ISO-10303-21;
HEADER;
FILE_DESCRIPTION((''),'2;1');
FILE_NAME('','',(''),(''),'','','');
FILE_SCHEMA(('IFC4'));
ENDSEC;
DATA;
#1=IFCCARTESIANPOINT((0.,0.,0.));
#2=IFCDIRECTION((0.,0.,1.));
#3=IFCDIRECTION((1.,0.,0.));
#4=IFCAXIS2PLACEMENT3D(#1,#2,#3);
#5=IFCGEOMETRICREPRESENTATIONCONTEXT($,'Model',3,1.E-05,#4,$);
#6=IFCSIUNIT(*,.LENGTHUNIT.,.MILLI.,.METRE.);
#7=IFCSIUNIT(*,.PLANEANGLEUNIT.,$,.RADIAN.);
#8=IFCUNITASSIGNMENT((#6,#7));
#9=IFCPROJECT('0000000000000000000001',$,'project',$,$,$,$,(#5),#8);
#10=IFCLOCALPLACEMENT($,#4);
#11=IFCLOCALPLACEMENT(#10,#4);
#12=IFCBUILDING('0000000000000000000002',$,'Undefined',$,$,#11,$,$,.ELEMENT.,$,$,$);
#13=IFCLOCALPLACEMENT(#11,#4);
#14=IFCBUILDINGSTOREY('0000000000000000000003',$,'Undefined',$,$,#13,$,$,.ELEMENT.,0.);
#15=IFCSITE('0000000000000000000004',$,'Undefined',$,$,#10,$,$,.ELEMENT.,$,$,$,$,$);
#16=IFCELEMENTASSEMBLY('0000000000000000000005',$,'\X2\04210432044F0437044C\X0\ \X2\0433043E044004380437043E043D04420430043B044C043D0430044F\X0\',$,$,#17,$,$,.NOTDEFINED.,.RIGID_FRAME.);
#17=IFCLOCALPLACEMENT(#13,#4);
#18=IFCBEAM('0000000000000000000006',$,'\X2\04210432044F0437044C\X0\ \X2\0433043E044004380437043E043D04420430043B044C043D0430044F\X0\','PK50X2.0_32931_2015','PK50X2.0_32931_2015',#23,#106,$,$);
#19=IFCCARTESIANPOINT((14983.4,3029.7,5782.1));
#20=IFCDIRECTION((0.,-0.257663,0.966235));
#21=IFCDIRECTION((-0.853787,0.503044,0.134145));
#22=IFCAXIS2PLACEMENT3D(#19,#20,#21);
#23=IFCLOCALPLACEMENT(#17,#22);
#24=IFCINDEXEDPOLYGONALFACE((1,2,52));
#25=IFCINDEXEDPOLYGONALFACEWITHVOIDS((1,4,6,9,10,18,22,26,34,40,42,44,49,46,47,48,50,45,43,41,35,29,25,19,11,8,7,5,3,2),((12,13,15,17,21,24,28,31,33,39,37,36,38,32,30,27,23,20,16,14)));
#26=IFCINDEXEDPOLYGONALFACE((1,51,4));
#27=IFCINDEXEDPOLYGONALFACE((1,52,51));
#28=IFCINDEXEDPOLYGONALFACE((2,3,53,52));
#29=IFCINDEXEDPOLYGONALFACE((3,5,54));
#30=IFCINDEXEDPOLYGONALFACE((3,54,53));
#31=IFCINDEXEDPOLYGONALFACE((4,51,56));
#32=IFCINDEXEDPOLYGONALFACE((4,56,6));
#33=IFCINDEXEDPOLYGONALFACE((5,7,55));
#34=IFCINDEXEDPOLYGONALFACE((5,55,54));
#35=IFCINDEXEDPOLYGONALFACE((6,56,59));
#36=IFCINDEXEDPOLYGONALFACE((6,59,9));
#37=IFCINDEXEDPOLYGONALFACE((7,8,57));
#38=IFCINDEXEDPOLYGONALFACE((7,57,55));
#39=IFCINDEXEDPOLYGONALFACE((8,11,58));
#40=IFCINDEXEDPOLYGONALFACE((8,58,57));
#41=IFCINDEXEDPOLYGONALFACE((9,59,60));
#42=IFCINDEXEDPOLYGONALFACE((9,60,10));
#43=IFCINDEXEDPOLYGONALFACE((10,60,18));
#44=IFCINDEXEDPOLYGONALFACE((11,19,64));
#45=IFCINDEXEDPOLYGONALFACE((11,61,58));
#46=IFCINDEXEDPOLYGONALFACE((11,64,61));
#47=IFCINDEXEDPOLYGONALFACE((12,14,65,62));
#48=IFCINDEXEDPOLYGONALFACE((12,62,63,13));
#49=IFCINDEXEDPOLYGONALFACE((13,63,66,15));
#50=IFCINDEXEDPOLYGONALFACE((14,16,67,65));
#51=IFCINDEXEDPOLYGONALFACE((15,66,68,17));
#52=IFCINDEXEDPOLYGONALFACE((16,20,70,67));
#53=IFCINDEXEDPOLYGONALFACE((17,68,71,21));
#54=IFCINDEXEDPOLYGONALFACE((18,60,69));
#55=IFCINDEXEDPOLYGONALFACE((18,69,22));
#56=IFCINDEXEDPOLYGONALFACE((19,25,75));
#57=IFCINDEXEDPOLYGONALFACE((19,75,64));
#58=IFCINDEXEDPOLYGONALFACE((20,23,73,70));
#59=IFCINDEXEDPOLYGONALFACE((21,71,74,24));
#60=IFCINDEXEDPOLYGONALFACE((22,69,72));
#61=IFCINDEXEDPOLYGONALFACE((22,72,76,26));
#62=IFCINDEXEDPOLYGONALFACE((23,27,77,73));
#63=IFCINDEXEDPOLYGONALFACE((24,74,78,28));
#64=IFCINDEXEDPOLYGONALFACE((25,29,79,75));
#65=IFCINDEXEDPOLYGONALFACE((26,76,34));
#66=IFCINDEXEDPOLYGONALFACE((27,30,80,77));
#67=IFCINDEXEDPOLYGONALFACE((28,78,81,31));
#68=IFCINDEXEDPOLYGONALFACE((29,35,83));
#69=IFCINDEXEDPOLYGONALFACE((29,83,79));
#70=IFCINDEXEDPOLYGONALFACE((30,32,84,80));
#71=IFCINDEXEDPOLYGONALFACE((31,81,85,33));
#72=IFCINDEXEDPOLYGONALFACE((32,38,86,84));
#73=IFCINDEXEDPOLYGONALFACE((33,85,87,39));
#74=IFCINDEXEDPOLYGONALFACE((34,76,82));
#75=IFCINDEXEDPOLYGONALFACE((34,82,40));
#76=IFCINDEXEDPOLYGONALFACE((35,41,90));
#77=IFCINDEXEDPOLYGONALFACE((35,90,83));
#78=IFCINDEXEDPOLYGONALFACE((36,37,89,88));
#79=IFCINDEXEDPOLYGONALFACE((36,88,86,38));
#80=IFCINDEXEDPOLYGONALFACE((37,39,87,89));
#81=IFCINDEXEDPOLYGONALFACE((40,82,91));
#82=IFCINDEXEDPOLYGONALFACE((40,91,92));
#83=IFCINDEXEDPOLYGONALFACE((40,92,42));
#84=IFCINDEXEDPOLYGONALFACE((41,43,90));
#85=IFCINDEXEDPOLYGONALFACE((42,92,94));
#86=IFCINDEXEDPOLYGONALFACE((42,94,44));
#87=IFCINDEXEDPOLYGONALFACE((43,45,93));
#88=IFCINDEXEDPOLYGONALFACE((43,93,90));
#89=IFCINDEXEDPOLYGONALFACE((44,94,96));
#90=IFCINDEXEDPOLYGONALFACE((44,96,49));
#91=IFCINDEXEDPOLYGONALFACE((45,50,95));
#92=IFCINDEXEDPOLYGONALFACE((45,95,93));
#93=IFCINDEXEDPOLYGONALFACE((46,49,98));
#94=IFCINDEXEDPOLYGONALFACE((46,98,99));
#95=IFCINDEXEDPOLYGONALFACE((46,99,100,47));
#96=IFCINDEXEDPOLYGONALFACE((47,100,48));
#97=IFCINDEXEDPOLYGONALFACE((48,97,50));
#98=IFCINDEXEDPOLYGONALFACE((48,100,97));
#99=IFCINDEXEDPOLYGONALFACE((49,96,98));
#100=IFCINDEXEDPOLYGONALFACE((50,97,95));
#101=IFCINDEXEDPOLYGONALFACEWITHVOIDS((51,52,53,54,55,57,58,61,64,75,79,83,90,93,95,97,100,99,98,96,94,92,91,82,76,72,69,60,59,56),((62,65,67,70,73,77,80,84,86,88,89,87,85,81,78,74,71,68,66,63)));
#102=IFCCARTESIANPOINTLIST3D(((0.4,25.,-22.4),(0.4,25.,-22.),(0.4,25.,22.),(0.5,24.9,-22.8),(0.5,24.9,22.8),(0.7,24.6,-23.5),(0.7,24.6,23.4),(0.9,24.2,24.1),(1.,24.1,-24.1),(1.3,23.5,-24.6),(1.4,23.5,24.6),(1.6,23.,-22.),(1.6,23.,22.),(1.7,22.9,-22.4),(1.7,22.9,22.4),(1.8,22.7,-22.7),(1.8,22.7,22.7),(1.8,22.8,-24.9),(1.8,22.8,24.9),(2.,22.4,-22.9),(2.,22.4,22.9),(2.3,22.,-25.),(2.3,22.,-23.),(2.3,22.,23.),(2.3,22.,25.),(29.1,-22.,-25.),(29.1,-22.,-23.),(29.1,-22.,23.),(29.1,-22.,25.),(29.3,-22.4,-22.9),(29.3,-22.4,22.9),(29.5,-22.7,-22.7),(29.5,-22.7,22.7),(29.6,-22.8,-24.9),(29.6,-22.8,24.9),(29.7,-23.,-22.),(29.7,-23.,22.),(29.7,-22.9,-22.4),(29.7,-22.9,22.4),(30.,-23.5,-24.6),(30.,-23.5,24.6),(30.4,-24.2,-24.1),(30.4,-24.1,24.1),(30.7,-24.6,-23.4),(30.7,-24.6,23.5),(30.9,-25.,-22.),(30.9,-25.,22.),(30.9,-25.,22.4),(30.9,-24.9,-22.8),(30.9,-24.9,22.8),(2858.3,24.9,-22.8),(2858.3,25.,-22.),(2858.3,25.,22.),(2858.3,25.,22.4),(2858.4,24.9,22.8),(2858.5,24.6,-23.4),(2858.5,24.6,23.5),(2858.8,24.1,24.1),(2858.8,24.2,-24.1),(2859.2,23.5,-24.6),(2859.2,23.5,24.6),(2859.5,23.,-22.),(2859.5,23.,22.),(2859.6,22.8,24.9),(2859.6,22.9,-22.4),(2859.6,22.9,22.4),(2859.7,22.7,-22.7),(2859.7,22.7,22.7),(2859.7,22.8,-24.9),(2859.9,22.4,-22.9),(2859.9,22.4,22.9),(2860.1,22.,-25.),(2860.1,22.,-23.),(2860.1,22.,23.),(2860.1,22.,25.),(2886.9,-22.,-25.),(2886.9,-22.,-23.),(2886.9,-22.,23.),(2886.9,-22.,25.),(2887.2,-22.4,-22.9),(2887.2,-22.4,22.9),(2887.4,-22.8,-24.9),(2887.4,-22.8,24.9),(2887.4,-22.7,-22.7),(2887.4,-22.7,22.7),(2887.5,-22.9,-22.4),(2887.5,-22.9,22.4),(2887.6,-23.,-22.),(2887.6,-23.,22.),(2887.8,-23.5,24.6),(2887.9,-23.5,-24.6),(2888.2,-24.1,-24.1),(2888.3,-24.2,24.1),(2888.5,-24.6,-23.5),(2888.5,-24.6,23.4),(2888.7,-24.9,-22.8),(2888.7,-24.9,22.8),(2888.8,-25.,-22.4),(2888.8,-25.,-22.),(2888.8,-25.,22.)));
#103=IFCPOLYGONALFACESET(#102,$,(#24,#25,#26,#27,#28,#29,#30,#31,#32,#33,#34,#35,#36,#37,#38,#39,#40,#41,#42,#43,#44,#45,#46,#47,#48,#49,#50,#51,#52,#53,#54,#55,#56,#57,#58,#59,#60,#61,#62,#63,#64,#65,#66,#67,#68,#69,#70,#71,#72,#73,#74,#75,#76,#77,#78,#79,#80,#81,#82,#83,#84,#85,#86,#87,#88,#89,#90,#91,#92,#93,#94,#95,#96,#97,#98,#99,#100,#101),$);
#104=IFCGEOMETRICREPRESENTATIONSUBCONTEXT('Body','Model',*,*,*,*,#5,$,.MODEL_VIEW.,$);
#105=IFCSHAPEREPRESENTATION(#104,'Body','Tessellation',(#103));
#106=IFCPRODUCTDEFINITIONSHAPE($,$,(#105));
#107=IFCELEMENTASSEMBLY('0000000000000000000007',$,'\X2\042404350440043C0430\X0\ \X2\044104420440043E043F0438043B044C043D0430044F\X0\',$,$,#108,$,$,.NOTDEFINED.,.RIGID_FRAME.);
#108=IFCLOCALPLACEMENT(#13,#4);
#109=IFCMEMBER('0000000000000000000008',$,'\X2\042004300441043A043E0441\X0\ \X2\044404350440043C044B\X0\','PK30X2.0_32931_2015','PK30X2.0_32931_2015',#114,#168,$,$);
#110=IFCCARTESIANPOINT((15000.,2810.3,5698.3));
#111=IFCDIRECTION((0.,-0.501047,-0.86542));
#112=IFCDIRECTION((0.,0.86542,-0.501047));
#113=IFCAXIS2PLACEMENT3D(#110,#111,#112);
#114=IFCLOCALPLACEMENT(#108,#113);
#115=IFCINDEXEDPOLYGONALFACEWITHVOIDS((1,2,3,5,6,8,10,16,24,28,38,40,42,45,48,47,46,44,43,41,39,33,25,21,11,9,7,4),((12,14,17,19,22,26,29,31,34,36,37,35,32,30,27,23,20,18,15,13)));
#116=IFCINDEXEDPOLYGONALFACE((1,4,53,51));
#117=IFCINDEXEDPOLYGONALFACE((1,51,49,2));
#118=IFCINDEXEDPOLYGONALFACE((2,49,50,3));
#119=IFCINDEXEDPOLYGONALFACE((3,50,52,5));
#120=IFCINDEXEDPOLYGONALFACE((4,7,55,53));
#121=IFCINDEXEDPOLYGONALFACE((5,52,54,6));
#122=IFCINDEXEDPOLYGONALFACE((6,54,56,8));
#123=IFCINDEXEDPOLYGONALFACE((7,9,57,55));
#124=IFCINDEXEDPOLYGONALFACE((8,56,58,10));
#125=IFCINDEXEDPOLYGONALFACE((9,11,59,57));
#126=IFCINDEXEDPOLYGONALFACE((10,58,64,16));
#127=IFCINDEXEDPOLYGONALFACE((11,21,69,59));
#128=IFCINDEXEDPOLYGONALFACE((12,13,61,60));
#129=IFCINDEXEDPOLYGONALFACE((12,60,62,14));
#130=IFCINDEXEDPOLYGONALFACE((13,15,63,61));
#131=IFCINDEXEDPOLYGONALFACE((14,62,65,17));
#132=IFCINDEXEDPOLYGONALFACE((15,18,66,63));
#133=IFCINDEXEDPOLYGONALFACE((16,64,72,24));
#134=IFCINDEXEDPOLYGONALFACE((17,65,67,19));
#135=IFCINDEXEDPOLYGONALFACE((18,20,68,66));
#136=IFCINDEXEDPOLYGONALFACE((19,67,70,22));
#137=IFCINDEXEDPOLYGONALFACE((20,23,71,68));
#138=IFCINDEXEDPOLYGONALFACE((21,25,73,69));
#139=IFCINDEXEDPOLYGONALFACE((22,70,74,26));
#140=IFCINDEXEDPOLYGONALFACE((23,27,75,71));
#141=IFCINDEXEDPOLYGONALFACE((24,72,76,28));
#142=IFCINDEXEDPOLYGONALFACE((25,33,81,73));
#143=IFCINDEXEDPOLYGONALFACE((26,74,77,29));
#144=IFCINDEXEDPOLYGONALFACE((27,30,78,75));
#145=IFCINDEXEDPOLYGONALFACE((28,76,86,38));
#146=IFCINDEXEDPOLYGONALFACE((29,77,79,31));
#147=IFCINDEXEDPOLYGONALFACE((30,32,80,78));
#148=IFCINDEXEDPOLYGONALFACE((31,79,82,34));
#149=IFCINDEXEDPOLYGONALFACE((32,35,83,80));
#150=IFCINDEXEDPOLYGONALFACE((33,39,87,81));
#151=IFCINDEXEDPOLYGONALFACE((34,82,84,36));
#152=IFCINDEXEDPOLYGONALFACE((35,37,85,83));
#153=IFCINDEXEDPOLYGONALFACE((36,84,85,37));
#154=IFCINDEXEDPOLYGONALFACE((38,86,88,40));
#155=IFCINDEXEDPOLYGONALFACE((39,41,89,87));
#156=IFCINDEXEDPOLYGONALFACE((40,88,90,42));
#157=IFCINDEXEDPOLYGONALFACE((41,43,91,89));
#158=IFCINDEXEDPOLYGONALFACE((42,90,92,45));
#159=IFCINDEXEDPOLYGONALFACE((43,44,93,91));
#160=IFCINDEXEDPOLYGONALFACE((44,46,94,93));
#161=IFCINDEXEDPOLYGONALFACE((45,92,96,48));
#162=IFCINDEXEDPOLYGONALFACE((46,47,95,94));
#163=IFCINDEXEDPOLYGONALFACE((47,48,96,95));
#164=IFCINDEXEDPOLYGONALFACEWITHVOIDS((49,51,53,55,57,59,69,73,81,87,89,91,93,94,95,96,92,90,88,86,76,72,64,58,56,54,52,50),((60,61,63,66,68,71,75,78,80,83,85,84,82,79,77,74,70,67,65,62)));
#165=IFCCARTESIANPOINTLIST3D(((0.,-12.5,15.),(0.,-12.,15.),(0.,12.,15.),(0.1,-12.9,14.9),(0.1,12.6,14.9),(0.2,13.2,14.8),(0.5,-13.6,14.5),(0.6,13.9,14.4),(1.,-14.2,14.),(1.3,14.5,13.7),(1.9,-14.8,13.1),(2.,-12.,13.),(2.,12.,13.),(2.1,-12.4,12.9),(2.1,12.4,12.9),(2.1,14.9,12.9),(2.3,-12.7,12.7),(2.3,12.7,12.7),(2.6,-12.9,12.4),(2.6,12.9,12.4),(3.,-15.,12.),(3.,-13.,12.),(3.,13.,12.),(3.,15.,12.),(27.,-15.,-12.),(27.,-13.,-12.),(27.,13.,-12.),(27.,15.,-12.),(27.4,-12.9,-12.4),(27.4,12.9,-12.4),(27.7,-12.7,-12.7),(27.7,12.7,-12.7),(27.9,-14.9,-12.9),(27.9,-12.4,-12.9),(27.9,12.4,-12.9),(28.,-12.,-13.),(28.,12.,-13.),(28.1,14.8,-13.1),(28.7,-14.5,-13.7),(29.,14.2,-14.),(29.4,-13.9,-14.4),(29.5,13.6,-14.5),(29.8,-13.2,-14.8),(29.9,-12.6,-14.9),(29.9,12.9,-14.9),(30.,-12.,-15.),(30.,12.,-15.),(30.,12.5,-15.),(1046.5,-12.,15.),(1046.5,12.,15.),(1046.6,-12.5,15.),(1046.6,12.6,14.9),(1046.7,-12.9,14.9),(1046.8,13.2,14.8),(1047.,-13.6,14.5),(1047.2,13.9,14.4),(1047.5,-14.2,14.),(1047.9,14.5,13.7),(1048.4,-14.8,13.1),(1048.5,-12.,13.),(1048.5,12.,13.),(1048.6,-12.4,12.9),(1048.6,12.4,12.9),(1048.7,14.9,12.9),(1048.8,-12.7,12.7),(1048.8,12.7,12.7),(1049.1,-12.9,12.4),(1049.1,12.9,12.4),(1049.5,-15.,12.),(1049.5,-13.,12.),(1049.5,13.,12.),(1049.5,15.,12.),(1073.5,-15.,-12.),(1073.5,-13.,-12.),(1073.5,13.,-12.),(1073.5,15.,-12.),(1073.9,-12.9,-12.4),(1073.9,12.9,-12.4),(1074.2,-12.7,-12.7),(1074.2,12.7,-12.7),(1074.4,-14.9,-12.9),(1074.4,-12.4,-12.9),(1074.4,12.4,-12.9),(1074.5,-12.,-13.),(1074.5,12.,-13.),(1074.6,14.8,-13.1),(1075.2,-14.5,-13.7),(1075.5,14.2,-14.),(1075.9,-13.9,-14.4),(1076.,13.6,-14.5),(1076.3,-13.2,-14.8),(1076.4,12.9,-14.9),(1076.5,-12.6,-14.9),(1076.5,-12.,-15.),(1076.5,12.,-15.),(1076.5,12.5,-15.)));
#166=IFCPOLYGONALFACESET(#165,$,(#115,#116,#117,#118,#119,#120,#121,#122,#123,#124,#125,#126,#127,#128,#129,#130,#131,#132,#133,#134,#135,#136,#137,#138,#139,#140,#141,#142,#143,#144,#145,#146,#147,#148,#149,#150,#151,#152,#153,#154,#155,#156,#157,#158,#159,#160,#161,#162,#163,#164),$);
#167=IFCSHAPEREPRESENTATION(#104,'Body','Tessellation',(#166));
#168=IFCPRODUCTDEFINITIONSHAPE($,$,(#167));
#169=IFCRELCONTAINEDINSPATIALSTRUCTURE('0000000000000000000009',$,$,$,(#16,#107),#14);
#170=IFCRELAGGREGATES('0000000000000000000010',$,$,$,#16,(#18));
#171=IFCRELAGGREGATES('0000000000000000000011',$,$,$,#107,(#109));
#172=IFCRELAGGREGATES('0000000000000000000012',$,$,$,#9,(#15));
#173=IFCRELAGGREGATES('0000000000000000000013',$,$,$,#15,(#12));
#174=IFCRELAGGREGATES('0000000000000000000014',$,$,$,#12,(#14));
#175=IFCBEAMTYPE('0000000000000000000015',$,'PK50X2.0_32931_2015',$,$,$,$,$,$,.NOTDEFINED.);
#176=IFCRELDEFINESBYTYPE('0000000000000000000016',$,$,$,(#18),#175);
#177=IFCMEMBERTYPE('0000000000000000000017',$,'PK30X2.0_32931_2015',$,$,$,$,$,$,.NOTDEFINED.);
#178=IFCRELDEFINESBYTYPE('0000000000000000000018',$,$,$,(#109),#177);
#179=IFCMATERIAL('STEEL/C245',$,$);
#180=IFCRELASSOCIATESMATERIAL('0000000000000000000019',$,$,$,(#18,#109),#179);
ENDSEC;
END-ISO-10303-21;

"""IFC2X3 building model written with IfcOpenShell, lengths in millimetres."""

from ifc_helpers import new_model, si_unit, frame, origin_with_axes, origin_2d_with_axis, place, context, subcontext, project, spatial, hollow_rectangle, extrude, clip, halfspace, material, type_object, element, aggregate, save


model = new_model("IFC2X3")

# Units and contexts
model_context = context("Model", 3, precision=1e-05, world=origin_with_axes())
body_context = subcontext(model_context, "Body", "Model", "MODEL_VIEW")
ifc_project = project(units=[si_unit("LENGTHUNIT", "METRE", prefix="MILLI"), si_unit("PLANEANGLEUNIT", "RADIAN")], contexts=[model_context])

# Site, building, storey
site_placement = place(None, origin_with_axes())
site = spatial("IfcSite", under=ifc_project, at=site_placement, Name="Undefined", CompositionType="ELEMENT")
building_placement = place(site_placement, origin_with_axes())
building = spatial("IfcBuilding", under=site, at=building_placement, Name="Undefined", CompositionType="ELEMENT")
storey_placement = place(building_placement, origin_with_axes())
storey = spatial("IfcBuildingStorey", under=building, at=storey_placement, Name="Undefined", CompositionType="ELEMENT", Elevation=0.0)

# Shared definitions
ifc_material_1 = material(Name="STEEL/C245")

# Element assembly, beam
assembly_1_placement = place(storey_placement, origin_with_axes())
assembly_1 = element("IfcElementAssembly", 1, at=assembly_1_placement, inside=storey, Name="Связь горизонтальная", AssemblyPlace="NOTDEFINED", PredefinedType="RIGID_FRAME")
beam_type_1 = type_object("IfcBeamType", Name="PK50X2.0_32931_2015", PredefinedType="NOTDEFINED")
beam_1_placement = place(assembly_1_placement, frame((14983.4, 3029.7, 5782.1), z_axis=(0.0, -0.257663, 0.966235), x_axis=(-0.853787, 0.503044, 0.134145)))
beam_1 = element("IfcBeam", 2, at=beam_1_placement, type_object=beam_type_1, material=ifc_material_1, Name="Связь горизонтальная", Description="PK50X2.0_32931_2015", ObjectType="PK50X2.0_32931_2015", context=body_context, shape_type="Clipping", body=[
    clip(clip(extrude(hollow_rectangle(XDim=50.0, YDim=50.0, WallThickness=2.0, InnerFilletRadius=1.0, OuterFilletRadius=3.0, at=origin_2d_with_axis()), frame((2917.4, 0.0, 0.0), z_axis=(-1.0, 0.0, 0.0), x_axis=(0.0, -1.0, 0.0)), (0.0, 0.0, 1.0), 2945.6), halfspace(frame((2920.7, -77.3, 25.0), z_axis=(-0.853787, -0.520623, 0.0), x_axis=(-0.520623, 0.853787, 0.0)), True)), halfspace(frame((48.4, -53.7, 25.0), z_axis=(0.853787, 0.520623, 0.0), x_axis=(0.520623, -0.853787, 0.0)), True)),
])
aggregate(assembly_1, [beam_1])

# Element assembly
assembly_2_placement = place(storey_placement, origin_with_axes())
assembly_2 = element("IfcElementAssembly", 3, at=assembly_2_placement, inside=storey, Name="Ферма стропильная", AssemblyPlace="NOTDEFINED", PredefinedType="RIGID_FRAME")

# Member
member_type_1 = type_object("IfcMemberType", Name="PK30X2.0_32931_2015", PredefinedType="NOTDEFINED")
member_1_placement = place(assembly_2_placement, frame((15000.0, 2810.3, 5698.3), z_axis=(0.0, -0.501047, -0.86542), x_axis=(0.0, 0.86542, -0.501047)))
member_1 = element("IfcMember", 4, at=member_1_placement, type_object=member_type_1, material=ifc_material_1, Name="Раскос фермы", Description="PK30X2.0_32931_2015", ObjectType="PK30X2.0_32931_2015", context=body_context, shape_type="Clipping", body=[
    clip(clip(extrude(hollow_rectangle(XDim=30.0, YDim=30.0, WallThickness=2.0, InnerFilletRadius=1.0, OuterFilletRadius=3.0, at=origin_2d_with_axis()), frame((1102.9, 0.0, 0.0), z_axis=(-1.0, 0.0, 0.0), x_axis=(0.0, -1.0, 0.0)), (0.0, 0.0, 1.0), 1129.2), halfspace(frame((1060.0, 0.0, 1.5), z_axis=(-0.707107, 0.0, -0.707107), x_axis=(0.0, -1.0, 0.0)), True)), halfspace(frame((34.5, 0.0, -19.5), z_axis=(-0.707107, 0.0, -0.707107), x_axis=(0.0, -1.0, 0.0)), False)),
])
aggregate(assembly_2, [member_1])

save(model, "model.ifc")
